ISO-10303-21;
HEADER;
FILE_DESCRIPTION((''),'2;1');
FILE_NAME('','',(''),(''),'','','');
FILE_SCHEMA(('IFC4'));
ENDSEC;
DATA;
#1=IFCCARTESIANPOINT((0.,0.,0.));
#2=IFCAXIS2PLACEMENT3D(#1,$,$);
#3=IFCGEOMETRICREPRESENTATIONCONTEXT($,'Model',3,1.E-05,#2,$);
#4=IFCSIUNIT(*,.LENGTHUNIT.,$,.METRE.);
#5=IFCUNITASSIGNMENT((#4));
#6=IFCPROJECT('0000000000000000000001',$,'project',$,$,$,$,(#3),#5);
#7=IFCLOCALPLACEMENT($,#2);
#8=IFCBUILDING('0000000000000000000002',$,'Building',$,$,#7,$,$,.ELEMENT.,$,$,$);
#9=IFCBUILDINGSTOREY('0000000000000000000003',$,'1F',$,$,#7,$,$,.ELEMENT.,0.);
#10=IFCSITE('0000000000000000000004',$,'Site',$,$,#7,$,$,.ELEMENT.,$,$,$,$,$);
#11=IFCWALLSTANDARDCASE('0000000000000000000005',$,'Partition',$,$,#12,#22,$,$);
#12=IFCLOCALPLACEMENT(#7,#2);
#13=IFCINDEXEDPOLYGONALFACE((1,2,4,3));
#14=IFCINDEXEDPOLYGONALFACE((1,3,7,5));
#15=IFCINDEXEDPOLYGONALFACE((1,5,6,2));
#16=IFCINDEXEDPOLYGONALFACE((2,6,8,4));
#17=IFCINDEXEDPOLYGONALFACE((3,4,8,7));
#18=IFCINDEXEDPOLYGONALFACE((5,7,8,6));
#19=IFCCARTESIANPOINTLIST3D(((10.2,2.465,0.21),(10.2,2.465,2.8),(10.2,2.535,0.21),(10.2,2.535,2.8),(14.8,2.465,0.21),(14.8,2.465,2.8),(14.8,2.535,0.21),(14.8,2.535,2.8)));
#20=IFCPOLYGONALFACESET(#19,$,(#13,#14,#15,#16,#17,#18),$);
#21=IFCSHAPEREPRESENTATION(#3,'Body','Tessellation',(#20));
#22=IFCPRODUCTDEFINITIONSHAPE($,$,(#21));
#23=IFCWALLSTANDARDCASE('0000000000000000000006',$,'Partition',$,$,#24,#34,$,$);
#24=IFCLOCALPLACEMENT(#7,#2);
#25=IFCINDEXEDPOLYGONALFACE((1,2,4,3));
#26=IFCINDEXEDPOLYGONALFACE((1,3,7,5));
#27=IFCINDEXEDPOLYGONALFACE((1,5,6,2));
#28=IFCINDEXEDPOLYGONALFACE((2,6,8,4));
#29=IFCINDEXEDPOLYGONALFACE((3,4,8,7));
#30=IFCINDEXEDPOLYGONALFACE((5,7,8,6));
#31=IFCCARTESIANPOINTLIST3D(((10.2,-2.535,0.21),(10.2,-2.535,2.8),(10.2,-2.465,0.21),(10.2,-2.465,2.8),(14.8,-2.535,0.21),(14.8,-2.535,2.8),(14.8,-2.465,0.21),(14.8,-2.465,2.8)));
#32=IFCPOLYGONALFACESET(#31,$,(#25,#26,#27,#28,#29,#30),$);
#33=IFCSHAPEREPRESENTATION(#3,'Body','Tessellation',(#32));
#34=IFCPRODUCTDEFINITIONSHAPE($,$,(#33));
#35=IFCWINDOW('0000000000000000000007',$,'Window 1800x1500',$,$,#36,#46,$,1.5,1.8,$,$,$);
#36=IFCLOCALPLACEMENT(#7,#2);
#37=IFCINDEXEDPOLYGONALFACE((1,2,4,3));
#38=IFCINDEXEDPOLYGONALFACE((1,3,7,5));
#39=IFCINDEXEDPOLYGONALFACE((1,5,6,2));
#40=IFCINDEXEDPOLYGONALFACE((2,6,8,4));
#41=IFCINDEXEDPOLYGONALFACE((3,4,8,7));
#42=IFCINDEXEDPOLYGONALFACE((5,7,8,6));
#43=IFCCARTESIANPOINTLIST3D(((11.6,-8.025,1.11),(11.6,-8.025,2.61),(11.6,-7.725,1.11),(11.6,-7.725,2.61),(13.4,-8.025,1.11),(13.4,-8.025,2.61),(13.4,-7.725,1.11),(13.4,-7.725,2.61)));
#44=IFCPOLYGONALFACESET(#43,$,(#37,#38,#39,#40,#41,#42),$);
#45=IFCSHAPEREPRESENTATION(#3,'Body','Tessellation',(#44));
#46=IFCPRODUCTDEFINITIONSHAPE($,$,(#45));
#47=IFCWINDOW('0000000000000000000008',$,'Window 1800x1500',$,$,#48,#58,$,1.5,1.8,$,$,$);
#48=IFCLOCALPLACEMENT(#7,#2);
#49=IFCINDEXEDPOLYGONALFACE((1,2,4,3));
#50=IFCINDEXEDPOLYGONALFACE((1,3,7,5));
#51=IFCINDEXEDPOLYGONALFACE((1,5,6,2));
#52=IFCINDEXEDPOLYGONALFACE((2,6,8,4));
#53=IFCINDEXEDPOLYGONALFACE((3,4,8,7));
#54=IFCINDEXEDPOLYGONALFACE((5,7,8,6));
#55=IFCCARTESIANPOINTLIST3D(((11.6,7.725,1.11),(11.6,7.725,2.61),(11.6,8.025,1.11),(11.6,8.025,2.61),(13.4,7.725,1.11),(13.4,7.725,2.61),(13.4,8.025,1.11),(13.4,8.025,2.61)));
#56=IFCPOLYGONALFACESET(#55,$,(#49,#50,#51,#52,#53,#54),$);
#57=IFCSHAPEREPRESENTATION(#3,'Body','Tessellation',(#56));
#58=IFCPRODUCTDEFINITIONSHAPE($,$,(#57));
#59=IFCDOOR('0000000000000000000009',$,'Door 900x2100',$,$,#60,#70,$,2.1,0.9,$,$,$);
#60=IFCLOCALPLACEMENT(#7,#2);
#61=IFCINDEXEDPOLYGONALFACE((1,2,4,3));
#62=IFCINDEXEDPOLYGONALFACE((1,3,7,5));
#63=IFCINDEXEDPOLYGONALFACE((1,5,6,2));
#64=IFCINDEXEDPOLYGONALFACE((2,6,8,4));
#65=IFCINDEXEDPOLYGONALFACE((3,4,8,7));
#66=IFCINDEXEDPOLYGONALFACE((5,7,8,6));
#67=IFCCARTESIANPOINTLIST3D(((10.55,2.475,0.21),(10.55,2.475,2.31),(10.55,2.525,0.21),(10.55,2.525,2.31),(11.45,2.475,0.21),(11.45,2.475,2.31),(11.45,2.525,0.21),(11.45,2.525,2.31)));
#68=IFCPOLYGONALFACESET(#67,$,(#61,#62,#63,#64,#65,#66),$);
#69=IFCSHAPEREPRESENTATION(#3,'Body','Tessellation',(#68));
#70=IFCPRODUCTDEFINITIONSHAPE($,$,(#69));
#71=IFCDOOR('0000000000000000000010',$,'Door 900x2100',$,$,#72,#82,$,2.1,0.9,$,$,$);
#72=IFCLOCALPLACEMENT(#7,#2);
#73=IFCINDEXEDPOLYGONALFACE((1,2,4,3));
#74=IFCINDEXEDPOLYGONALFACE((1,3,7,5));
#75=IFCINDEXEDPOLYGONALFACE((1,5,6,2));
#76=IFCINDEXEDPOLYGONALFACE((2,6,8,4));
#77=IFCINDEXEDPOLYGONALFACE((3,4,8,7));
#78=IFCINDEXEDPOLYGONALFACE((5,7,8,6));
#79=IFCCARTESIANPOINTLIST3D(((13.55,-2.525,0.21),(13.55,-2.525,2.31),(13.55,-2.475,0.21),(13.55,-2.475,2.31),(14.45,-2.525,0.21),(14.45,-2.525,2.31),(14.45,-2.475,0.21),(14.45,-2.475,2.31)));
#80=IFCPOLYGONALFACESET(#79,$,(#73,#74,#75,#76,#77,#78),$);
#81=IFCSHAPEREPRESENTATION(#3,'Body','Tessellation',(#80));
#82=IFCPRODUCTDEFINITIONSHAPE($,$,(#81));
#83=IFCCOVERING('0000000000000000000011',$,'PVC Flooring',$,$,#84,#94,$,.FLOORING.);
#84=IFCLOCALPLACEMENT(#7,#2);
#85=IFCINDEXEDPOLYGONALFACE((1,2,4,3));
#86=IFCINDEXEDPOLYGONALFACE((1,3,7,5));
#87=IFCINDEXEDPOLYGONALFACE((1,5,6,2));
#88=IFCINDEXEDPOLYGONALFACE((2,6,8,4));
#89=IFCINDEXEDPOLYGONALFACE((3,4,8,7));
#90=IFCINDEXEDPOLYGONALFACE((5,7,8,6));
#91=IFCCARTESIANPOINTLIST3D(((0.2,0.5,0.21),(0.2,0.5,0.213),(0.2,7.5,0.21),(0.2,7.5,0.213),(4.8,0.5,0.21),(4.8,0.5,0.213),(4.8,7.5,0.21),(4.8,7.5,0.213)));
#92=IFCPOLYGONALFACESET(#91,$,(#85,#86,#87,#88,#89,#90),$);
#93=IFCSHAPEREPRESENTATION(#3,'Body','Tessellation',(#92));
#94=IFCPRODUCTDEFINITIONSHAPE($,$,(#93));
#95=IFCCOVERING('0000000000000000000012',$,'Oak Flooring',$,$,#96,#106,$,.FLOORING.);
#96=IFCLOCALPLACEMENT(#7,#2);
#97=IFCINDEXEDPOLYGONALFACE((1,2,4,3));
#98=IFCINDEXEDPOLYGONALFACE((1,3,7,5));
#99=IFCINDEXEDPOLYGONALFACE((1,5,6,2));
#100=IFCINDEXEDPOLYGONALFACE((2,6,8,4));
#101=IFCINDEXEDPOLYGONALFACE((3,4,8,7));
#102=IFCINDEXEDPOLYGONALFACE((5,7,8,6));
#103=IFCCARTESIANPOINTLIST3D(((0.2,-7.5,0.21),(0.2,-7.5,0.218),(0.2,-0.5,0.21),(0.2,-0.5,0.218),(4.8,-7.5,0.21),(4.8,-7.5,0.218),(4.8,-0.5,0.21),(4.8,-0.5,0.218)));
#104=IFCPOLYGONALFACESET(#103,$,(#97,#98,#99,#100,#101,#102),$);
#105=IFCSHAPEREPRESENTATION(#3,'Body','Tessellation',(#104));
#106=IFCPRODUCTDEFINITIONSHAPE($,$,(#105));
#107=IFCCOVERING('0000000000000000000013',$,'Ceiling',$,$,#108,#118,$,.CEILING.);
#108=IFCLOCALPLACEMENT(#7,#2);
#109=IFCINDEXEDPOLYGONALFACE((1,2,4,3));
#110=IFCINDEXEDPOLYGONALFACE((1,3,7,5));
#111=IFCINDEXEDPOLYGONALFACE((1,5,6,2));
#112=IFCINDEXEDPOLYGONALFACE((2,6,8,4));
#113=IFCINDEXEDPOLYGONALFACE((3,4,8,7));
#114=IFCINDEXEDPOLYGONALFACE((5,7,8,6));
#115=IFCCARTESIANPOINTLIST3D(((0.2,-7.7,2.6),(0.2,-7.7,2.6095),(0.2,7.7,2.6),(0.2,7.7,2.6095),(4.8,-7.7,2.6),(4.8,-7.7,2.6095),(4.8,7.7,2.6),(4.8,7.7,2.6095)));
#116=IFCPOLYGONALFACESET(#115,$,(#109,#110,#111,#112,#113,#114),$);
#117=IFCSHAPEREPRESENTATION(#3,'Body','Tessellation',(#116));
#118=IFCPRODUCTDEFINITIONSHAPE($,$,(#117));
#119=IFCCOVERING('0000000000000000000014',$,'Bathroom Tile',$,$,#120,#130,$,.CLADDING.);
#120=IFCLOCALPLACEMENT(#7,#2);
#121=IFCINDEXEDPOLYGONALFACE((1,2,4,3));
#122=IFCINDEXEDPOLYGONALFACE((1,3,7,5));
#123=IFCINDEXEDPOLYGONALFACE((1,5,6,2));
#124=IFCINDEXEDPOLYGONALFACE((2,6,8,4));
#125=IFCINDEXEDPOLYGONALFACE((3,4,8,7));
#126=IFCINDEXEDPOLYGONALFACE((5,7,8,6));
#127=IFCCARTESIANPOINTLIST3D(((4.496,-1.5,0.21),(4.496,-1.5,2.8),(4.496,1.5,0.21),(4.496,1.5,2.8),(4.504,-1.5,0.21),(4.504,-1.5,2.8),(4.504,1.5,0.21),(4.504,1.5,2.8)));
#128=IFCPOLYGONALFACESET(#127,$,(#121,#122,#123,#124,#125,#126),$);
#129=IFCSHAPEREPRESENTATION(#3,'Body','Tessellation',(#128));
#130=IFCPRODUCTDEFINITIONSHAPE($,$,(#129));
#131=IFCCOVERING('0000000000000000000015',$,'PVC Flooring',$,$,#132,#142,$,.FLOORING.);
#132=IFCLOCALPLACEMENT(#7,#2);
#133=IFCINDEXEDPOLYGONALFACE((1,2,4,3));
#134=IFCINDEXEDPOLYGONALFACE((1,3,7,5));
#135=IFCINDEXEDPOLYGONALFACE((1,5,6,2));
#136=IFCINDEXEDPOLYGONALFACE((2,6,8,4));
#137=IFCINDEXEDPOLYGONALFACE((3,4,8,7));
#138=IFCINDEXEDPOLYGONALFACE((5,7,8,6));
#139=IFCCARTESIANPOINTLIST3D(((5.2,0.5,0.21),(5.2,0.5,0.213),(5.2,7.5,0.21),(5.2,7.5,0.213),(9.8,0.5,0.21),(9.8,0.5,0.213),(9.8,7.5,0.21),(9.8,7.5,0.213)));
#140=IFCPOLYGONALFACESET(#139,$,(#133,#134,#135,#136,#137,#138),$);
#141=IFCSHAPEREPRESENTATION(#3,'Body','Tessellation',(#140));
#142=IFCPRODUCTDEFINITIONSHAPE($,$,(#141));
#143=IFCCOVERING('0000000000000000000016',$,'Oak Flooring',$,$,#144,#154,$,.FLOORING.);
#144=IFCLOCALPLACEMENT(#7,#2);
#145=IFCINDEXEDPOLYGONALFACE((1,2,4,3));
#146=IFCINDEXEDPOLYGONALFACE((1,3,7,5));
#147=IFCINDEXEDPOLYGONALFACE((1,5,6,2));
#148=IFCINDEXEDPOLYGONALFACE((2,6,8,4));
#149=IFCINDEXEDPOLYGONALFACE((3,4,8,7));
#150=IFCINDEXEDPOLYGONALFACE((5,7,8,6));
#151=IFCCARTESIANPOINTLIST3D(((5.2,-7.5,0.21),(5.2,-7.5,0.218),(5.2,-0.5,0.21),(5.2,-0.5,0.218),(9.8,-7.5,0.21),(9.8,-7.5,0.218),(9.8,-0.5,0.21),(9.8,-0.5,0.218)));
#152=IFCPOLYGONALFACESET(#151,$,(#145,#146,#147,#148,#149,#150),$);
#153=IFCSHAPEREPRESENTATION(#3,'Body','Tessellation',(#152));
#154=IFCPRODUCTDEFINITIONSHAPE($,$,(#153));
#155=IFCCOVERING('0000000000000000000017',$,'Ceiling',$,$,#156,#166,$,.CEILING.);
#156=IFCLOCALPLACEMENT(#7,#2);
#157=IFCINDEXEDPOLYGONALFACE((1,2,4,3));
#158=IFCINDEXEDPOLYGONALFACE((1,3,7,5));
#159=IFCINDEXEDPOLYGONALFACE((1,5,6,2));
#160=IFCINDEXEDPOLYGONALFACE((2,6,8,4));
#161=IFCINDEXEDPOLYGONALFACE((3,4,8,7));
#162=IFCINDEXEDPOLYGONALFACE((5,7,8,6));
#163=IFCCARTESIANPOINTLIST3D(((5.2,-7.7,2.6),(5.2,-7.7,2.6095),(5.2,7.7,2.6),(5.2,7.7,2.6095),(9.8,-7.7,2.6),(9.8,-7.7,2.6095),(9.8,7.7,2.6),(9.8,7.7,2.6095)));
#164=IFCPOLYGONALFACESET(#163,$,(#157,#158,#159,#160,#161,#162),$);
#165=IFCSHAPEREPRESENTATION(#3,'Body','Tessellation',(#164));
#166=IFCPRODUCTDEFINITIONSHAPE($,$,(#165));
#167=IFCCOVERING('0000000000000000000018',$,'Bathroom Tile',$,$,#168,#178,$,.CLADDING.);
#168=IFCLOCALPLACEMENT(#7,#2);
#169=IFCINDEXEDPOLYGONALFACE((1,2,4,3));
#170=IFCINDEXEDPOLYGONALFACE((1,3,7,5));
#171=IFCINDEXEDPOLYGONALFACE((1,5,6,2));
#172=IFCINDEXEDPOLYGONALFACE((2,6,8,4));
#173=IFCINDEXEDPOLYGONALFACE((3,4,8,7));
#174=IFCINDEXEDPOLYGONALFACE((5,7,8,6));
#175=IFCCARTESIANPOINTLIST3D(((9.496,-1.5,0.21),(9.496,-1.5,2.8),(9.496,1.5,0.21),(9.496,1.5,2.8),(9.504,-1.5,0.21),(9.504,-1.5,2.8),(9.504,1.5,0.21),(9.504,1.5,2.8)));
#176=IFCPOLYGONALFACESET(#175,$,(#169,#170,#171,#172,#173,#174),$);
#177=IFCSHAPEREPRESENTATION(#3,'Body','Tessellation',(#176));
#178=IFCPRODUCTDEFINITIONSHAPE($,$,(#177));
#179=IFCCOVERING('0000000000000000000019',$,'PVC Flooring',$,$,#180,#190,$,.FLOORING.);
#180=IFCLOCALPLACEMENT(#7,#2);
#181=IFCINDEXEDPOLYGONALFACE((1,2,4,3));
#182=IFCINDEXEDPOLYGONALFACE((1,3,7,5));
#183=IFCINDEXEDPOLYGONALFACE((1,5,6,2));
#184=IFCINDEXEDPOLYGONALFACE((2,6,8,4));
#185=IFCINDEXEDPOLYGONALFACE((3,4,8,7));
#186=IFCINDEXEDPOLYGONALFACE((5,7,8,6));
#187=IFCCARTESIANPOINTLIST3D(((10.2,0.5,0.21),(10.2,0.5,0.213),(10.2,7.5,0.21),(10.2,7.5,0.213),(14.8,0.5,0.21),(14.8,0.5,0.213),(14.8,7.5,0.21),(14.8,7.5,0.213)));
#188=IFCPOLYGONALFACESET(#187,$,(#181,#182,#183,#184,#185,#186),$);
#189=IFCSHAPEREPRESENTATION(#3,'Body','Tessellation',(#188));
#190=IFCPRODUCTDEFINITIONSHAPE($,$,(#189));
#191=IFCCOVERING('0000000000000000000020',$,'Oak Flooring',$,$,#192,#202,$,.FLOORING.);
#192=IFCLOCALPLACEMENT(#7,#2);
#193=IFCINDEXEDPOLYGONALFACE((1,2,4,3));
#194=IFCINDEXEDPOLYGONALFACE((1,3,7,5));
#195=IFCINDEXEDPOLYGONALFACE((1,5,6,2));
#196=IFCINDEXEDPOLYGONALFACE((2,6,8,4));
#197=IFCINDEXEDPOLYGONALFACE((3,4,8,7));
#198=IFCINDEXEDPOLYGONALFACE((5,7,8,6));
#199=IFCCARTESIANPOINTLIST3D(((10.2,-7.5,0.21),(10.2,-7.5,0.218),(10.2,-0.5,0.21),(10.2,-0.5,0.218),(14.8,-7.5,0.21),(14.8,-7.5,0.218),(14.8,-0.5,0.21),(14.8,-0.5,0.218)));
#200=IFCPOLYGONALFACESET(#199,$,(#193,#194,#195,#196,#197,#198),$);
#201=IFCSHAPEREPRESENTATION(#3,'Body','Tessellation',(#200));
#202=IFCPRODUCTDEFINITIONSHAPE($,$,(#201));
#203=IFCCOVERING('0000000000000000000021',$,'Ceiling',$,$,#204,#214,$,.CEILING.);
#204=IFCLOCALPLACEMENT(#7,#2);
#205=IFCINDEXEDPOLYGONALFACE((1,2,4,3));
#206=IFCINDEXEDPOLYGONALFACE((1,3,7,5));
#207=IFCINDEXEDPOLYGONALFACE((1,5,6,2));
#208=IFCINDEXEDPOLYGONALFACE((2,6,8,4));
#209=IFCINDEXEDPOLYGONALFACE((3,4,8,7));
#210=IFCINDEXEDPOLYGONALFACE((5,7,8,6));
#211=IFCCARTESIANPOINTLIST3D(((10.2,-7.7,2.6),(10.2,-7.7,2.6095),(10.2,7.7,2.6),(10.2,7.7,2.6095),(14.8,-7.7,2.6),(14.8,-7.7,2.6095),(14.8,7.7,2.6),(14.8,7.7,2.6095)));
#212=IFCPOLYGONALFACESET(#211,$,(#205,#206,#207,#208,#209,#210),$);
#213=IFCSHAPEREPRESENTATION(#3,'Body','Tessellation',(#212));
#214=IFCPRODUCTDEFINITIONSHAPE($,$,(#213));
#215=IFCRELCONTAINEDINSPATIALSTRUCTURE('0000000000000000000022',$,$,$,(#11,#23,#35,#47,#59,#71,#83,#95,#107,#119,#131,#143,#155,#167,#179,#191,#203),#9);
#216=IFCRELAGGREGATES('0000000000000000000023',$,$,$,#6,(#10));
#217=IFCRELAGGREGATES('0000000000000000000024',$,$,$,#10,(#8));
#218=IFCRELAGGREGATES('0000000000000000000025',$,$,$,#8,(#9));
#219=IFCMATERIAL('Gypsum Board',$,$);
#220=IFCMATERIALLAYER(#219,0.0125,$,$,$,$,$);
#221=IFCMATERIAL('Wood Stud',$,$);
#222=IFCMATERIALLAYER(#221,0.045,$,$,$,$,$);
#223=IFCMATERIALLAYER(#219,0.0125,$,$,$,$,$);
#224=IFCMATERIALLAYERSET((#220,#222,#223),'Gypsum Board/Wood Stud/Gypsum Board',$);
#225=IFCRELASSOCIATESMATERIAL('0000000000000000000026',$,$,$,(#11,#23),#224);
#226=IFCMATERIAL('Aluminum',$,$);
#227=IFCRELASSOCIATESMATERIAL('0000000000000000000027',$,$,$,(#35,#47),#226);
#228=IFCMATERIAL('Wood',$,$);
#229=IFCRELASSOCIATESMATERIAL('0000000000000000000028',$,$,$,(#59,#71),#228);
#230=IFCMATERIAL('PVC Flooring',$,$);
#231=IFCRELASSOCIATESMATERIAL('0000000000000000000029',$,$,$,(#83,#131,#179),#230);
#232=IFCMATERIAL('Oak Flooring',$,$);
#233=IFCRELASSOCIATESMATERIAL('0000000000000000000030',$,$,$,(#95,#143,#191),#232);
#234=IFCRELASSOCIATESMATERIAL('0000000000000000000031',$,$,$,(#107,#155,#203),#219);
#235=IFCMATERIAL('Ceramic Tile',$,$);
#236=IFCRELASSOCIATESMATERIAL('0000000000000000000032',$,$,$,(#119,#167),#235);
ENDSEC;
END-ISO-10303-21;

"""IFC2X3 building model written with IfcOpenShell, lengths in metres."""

from ifc_helpers import new_model, si_unit, frame, origin, origin_2d, place, context, project, spatial, rectangle, extrude, material, layer, layer_set, layer_usage, element, save


model = new_model("IFC2X3")

# Units and contexts
model_context = context("Model", 3, precision=1e-05, world=origin())
ifc_project = project(units=[si_unit("LENGTHUNIT", "METRE")], contexts=[model_context])

# Site, building, storey
placement = place(None, origin())
site = spatial("IfcSite", under=ifc_project, at=placement, Name="Site", CompositionType="ELEMENT")
building = spatial("IfcBuilding", under=site, at=placement, Name="Building", CompositionType="ELEMENT")
storey = spatial("IfcBuildingStorey", under=building, at=placement, Name="1F", CompositionType="ELEMENT", Elevation=0.0)

# Shared definitions
ifc_material_1 = material(Name="Gypsum Board")
ifc_layer_1 = layer(ifc_material_1, 0.0125)
ifc_material_2 = material(Name="Wood Stud")
ifc_layer_2 = layer(ifc_material_2, 0.045)
ifc_layer_3 = layer(ifc_material_1, 0.0125)
ifc_layer_set_1 = layer_set([ifc_layer_1, ifc_layer_2, ifc_layer_3], Name="Gypsum Board/Wood Stud/Gypsum Board")
ifc_layer_usage_1 = layer_usage(ifc_layer_set_1, "AXIS2", "POSITIVE", 0.0)

# Shared definitions
ifc_material_3 = material(Name="Aluminum")

# Shared definitions
ifc_material_4 = material(Name="Wood")

# Walls
for number, where, name in (
    (1, (12.5, 2.5, 0.21), "Partition"),
    (2, (12.5, -2.5, 0.21), "Partition"),
):
    element("IfcWallStandardCase", number, at=place(None, frame(where)), inside=storey, material=ifc_layer_usage_1, Name=name, context=model_context, shape_type="SweptSolid", body=[
        extrude(rectangle(XDim=4.6, YDim=0.07, at=origin_2d()), origin(), (0.0, 0.0, 1.0), 2.59),
    ])

# Windows
for number, where, name in (
    (3, (12.5, -7.875, 1.11), "Window 1800x1500"),
    (4, (12.5, 7.875, 1.11), "Window 1800x1500"),
):
    element("IfcWindow", number, at=place(None, frame(where)), inside=storey, material=ifc_material_3, Name=name, OverallHeight=1.5, OverallWidth=1.8, context=model_context, shape_type="SweptSolid", body=[
        extrude(rectangle(XDim=1.8, YDim=0.3, at=origin_2d()), origin(), (0.0, 0.0, 1.0), 1.5),
    ])

# Doors
for number, where, name in (
    (5, (11.0, 2.5, 0.21), "Door 900x2100"),
    (6, (14.0, -2.5, 0.21), "Door 900x2100"),
):
    element("IfcDoor", number, at=place(None, frame(where)), inside=storey, material=ifc_material_4, Name=name, OverallHeight=2.1, OverallWidth=0.9, context=model_context, shape_type="SweptSolid", body=[
        extrude(rectangle(XDim=0.9, YDim=0.05, at=origin_2d()), origin(), (0.0, 0.0, 1.0), 2.1),
    ])

# Coverings
ifc_material_5 = material(Name="PVC Flooring")
covering_1_placement = place(None, frame((2.5, 4.0, 0.21)))
element("IfcCovering", 7, at=covering_1_placement, inside=storey, material=ifc_material_5, Name="PVC Flooring", PredefinedType="FLOORING", context=model_context, shape_type="SweptSolid", body=[
    extrude(rectangle(XDim=4.6, YDim=7.0, at=origin_2d()), origin(), (0.0, 0.0, 1.0), 0.003),
])
ifc_material_6 = material(Name="Oak Flooring")
covering_2_placement = place(None, frame((2.5, -4.0, 0.21)))
element("IfcCovering", 8, at=covering_2_placement, inside=storey, material=ifc_material_6, Name="Oak Flooring", PredefinedType="FLOORING", context=model_context, shape_type="SweptSolid", body=[
    extrude(rectangle(XDim=4.6, YDim=7.0, at=origin_2d()), origin(), (0.0, 0.0, 1.0), 0.008),
])
covering_3_placement = place(None, frame((2.5, 0.0, 2.6)))
element("IfcCovering", 9, at=covering_3_placement, inside=storey, material=ifc_material_1, Name="Ceiling", PredefinedType="CEILING", context=model_context, shape_type="SweptSolid", body=[
    extrude(rectangle(XDim=4.6, YDim=15.4, at=origin_2d()), origin(), (0.0, 0.0, 1.0), 0.0095),
])
ifc_material_7 = material(Name="Ceramic Tile")
covering_4_placement = place(None, frame((4.5, 0.0, 0.21)))
element("IfcCovering", 10, at=covering_4_placement, inside=storey, material=ifc_material_7, Name="Bathroom Tile", PredefinedType="CLADDING", context=model_context, shape_type="SweptSolid", body=[
    extrude(rectangle(XDim=0.008, YDim=3.0, at=origin_2d()), origin(), (0.0, 0.0, 1.0), 2.59),
])
covering_5_placement = place(None, frame((7.5, 4.0, 0.21)))
element("IfcCovering", 11, at=covering_5_placement, inside=storey, material=ifc_material_5, Name="PVC Flooring", PredefinedType="FLOORING", context=model_context, shape_type="SweptSolid", body=[
    extrude(rectangle(XDim=4.6, YDim=7.0, at=origin_2d()), origin(), (0.0, 0.0, 1.0), 0.003),
])
covering_6_placement = place(None, frame((7.5, -4.0, 0.21)))
element("IfcCovering", 12, at=covering_6_placement, inside=storey, material=ifc_material_6, Name="Oak Flooring", PredefinedType="FLOORING", context=model_context, shape_type="SweptSolid", body=[
    extrude(rectangle(XDim=4.6, YDim=7.0, at=origin_2d()), origin(), (0.0, 0.0, 1.0), 0.008),
])
covering_7_placement = place(None, frame((7.5, 0.0, 2.6)))
element("IfcCovering", 13, at=covering_7_placement, inside=storey, material=ifc_material_1, Name="Ceiling", PredefinedType="CEILING", context=model_context, shape_type="SweptSolid", body=[
    extrude(rectangle(XDim=4.6, YDim=15.4, at=origin_2d()), origin(), (0.0, 0.0, 1.0), 0.0095),
])
covering_8_placement = place(None, frame((9.5, 0.0, 0.21)))
element("IfcCovering", 14, at=covering_8_placement, inside=storey, material=ifc_material_7, Name="Bathroom Tile", PredefinedType="CLADDING", context=model_context, shape_type="SweptSolid", body=[
    extrude(rectangle(XDim=0.008, YDim=3.0, at=origin_2d()), origin(), (0.0, 0.0, 1.0), 2.59),
])
covering_9_placement = place(None, frame((12.5, 4.0, 0.21)))
element("IfcCovering", 15, at=covering_9_placement, inside=storey, material=ifc_material_5, Name="PVC Flooring", PredefinedType="FLOORING", context=model_context, shape_type="SweptSolid", body=[
    extrude(rectangle(XDim=4.6, YDim=7.0, at=origin_2d()), origin(), (0.0, 0.0, 1.0), 0.003),
])
covering_10_placement = place(None, frame((12.5, -4.0, 0.21)))
element("IfcCovering", 16, at=covering_10_placement, inside=storey, material=ifc_material_6, Name="Oak Flooring", PredefinedType="FLOORING", context=model_context, shape_type="SweptSolid", body=[
    extrude(rectangle(XDim=4.6, YDim=7.0, at=origin_2d()), origin(), (0.0, 0.0, 1.0), 0.008),
])
covering_11_placement = place(None, frame((12.5, 0.0, 2.6)))
element("IfcCovering", 17, at=covering_11_placement, inside=storey, material=ifc_material_1, Name="Ceiling", PredefinedType="CEILING", context=model_context, shape_type="SweptSolid", body=[
    extrude(rectangle(XDim=4.6, YDim=15.4, at=origin_2d()), origin(), (0.0, 0.0, 1.0), 0.0095),
])

save(model, "model.ifc")
